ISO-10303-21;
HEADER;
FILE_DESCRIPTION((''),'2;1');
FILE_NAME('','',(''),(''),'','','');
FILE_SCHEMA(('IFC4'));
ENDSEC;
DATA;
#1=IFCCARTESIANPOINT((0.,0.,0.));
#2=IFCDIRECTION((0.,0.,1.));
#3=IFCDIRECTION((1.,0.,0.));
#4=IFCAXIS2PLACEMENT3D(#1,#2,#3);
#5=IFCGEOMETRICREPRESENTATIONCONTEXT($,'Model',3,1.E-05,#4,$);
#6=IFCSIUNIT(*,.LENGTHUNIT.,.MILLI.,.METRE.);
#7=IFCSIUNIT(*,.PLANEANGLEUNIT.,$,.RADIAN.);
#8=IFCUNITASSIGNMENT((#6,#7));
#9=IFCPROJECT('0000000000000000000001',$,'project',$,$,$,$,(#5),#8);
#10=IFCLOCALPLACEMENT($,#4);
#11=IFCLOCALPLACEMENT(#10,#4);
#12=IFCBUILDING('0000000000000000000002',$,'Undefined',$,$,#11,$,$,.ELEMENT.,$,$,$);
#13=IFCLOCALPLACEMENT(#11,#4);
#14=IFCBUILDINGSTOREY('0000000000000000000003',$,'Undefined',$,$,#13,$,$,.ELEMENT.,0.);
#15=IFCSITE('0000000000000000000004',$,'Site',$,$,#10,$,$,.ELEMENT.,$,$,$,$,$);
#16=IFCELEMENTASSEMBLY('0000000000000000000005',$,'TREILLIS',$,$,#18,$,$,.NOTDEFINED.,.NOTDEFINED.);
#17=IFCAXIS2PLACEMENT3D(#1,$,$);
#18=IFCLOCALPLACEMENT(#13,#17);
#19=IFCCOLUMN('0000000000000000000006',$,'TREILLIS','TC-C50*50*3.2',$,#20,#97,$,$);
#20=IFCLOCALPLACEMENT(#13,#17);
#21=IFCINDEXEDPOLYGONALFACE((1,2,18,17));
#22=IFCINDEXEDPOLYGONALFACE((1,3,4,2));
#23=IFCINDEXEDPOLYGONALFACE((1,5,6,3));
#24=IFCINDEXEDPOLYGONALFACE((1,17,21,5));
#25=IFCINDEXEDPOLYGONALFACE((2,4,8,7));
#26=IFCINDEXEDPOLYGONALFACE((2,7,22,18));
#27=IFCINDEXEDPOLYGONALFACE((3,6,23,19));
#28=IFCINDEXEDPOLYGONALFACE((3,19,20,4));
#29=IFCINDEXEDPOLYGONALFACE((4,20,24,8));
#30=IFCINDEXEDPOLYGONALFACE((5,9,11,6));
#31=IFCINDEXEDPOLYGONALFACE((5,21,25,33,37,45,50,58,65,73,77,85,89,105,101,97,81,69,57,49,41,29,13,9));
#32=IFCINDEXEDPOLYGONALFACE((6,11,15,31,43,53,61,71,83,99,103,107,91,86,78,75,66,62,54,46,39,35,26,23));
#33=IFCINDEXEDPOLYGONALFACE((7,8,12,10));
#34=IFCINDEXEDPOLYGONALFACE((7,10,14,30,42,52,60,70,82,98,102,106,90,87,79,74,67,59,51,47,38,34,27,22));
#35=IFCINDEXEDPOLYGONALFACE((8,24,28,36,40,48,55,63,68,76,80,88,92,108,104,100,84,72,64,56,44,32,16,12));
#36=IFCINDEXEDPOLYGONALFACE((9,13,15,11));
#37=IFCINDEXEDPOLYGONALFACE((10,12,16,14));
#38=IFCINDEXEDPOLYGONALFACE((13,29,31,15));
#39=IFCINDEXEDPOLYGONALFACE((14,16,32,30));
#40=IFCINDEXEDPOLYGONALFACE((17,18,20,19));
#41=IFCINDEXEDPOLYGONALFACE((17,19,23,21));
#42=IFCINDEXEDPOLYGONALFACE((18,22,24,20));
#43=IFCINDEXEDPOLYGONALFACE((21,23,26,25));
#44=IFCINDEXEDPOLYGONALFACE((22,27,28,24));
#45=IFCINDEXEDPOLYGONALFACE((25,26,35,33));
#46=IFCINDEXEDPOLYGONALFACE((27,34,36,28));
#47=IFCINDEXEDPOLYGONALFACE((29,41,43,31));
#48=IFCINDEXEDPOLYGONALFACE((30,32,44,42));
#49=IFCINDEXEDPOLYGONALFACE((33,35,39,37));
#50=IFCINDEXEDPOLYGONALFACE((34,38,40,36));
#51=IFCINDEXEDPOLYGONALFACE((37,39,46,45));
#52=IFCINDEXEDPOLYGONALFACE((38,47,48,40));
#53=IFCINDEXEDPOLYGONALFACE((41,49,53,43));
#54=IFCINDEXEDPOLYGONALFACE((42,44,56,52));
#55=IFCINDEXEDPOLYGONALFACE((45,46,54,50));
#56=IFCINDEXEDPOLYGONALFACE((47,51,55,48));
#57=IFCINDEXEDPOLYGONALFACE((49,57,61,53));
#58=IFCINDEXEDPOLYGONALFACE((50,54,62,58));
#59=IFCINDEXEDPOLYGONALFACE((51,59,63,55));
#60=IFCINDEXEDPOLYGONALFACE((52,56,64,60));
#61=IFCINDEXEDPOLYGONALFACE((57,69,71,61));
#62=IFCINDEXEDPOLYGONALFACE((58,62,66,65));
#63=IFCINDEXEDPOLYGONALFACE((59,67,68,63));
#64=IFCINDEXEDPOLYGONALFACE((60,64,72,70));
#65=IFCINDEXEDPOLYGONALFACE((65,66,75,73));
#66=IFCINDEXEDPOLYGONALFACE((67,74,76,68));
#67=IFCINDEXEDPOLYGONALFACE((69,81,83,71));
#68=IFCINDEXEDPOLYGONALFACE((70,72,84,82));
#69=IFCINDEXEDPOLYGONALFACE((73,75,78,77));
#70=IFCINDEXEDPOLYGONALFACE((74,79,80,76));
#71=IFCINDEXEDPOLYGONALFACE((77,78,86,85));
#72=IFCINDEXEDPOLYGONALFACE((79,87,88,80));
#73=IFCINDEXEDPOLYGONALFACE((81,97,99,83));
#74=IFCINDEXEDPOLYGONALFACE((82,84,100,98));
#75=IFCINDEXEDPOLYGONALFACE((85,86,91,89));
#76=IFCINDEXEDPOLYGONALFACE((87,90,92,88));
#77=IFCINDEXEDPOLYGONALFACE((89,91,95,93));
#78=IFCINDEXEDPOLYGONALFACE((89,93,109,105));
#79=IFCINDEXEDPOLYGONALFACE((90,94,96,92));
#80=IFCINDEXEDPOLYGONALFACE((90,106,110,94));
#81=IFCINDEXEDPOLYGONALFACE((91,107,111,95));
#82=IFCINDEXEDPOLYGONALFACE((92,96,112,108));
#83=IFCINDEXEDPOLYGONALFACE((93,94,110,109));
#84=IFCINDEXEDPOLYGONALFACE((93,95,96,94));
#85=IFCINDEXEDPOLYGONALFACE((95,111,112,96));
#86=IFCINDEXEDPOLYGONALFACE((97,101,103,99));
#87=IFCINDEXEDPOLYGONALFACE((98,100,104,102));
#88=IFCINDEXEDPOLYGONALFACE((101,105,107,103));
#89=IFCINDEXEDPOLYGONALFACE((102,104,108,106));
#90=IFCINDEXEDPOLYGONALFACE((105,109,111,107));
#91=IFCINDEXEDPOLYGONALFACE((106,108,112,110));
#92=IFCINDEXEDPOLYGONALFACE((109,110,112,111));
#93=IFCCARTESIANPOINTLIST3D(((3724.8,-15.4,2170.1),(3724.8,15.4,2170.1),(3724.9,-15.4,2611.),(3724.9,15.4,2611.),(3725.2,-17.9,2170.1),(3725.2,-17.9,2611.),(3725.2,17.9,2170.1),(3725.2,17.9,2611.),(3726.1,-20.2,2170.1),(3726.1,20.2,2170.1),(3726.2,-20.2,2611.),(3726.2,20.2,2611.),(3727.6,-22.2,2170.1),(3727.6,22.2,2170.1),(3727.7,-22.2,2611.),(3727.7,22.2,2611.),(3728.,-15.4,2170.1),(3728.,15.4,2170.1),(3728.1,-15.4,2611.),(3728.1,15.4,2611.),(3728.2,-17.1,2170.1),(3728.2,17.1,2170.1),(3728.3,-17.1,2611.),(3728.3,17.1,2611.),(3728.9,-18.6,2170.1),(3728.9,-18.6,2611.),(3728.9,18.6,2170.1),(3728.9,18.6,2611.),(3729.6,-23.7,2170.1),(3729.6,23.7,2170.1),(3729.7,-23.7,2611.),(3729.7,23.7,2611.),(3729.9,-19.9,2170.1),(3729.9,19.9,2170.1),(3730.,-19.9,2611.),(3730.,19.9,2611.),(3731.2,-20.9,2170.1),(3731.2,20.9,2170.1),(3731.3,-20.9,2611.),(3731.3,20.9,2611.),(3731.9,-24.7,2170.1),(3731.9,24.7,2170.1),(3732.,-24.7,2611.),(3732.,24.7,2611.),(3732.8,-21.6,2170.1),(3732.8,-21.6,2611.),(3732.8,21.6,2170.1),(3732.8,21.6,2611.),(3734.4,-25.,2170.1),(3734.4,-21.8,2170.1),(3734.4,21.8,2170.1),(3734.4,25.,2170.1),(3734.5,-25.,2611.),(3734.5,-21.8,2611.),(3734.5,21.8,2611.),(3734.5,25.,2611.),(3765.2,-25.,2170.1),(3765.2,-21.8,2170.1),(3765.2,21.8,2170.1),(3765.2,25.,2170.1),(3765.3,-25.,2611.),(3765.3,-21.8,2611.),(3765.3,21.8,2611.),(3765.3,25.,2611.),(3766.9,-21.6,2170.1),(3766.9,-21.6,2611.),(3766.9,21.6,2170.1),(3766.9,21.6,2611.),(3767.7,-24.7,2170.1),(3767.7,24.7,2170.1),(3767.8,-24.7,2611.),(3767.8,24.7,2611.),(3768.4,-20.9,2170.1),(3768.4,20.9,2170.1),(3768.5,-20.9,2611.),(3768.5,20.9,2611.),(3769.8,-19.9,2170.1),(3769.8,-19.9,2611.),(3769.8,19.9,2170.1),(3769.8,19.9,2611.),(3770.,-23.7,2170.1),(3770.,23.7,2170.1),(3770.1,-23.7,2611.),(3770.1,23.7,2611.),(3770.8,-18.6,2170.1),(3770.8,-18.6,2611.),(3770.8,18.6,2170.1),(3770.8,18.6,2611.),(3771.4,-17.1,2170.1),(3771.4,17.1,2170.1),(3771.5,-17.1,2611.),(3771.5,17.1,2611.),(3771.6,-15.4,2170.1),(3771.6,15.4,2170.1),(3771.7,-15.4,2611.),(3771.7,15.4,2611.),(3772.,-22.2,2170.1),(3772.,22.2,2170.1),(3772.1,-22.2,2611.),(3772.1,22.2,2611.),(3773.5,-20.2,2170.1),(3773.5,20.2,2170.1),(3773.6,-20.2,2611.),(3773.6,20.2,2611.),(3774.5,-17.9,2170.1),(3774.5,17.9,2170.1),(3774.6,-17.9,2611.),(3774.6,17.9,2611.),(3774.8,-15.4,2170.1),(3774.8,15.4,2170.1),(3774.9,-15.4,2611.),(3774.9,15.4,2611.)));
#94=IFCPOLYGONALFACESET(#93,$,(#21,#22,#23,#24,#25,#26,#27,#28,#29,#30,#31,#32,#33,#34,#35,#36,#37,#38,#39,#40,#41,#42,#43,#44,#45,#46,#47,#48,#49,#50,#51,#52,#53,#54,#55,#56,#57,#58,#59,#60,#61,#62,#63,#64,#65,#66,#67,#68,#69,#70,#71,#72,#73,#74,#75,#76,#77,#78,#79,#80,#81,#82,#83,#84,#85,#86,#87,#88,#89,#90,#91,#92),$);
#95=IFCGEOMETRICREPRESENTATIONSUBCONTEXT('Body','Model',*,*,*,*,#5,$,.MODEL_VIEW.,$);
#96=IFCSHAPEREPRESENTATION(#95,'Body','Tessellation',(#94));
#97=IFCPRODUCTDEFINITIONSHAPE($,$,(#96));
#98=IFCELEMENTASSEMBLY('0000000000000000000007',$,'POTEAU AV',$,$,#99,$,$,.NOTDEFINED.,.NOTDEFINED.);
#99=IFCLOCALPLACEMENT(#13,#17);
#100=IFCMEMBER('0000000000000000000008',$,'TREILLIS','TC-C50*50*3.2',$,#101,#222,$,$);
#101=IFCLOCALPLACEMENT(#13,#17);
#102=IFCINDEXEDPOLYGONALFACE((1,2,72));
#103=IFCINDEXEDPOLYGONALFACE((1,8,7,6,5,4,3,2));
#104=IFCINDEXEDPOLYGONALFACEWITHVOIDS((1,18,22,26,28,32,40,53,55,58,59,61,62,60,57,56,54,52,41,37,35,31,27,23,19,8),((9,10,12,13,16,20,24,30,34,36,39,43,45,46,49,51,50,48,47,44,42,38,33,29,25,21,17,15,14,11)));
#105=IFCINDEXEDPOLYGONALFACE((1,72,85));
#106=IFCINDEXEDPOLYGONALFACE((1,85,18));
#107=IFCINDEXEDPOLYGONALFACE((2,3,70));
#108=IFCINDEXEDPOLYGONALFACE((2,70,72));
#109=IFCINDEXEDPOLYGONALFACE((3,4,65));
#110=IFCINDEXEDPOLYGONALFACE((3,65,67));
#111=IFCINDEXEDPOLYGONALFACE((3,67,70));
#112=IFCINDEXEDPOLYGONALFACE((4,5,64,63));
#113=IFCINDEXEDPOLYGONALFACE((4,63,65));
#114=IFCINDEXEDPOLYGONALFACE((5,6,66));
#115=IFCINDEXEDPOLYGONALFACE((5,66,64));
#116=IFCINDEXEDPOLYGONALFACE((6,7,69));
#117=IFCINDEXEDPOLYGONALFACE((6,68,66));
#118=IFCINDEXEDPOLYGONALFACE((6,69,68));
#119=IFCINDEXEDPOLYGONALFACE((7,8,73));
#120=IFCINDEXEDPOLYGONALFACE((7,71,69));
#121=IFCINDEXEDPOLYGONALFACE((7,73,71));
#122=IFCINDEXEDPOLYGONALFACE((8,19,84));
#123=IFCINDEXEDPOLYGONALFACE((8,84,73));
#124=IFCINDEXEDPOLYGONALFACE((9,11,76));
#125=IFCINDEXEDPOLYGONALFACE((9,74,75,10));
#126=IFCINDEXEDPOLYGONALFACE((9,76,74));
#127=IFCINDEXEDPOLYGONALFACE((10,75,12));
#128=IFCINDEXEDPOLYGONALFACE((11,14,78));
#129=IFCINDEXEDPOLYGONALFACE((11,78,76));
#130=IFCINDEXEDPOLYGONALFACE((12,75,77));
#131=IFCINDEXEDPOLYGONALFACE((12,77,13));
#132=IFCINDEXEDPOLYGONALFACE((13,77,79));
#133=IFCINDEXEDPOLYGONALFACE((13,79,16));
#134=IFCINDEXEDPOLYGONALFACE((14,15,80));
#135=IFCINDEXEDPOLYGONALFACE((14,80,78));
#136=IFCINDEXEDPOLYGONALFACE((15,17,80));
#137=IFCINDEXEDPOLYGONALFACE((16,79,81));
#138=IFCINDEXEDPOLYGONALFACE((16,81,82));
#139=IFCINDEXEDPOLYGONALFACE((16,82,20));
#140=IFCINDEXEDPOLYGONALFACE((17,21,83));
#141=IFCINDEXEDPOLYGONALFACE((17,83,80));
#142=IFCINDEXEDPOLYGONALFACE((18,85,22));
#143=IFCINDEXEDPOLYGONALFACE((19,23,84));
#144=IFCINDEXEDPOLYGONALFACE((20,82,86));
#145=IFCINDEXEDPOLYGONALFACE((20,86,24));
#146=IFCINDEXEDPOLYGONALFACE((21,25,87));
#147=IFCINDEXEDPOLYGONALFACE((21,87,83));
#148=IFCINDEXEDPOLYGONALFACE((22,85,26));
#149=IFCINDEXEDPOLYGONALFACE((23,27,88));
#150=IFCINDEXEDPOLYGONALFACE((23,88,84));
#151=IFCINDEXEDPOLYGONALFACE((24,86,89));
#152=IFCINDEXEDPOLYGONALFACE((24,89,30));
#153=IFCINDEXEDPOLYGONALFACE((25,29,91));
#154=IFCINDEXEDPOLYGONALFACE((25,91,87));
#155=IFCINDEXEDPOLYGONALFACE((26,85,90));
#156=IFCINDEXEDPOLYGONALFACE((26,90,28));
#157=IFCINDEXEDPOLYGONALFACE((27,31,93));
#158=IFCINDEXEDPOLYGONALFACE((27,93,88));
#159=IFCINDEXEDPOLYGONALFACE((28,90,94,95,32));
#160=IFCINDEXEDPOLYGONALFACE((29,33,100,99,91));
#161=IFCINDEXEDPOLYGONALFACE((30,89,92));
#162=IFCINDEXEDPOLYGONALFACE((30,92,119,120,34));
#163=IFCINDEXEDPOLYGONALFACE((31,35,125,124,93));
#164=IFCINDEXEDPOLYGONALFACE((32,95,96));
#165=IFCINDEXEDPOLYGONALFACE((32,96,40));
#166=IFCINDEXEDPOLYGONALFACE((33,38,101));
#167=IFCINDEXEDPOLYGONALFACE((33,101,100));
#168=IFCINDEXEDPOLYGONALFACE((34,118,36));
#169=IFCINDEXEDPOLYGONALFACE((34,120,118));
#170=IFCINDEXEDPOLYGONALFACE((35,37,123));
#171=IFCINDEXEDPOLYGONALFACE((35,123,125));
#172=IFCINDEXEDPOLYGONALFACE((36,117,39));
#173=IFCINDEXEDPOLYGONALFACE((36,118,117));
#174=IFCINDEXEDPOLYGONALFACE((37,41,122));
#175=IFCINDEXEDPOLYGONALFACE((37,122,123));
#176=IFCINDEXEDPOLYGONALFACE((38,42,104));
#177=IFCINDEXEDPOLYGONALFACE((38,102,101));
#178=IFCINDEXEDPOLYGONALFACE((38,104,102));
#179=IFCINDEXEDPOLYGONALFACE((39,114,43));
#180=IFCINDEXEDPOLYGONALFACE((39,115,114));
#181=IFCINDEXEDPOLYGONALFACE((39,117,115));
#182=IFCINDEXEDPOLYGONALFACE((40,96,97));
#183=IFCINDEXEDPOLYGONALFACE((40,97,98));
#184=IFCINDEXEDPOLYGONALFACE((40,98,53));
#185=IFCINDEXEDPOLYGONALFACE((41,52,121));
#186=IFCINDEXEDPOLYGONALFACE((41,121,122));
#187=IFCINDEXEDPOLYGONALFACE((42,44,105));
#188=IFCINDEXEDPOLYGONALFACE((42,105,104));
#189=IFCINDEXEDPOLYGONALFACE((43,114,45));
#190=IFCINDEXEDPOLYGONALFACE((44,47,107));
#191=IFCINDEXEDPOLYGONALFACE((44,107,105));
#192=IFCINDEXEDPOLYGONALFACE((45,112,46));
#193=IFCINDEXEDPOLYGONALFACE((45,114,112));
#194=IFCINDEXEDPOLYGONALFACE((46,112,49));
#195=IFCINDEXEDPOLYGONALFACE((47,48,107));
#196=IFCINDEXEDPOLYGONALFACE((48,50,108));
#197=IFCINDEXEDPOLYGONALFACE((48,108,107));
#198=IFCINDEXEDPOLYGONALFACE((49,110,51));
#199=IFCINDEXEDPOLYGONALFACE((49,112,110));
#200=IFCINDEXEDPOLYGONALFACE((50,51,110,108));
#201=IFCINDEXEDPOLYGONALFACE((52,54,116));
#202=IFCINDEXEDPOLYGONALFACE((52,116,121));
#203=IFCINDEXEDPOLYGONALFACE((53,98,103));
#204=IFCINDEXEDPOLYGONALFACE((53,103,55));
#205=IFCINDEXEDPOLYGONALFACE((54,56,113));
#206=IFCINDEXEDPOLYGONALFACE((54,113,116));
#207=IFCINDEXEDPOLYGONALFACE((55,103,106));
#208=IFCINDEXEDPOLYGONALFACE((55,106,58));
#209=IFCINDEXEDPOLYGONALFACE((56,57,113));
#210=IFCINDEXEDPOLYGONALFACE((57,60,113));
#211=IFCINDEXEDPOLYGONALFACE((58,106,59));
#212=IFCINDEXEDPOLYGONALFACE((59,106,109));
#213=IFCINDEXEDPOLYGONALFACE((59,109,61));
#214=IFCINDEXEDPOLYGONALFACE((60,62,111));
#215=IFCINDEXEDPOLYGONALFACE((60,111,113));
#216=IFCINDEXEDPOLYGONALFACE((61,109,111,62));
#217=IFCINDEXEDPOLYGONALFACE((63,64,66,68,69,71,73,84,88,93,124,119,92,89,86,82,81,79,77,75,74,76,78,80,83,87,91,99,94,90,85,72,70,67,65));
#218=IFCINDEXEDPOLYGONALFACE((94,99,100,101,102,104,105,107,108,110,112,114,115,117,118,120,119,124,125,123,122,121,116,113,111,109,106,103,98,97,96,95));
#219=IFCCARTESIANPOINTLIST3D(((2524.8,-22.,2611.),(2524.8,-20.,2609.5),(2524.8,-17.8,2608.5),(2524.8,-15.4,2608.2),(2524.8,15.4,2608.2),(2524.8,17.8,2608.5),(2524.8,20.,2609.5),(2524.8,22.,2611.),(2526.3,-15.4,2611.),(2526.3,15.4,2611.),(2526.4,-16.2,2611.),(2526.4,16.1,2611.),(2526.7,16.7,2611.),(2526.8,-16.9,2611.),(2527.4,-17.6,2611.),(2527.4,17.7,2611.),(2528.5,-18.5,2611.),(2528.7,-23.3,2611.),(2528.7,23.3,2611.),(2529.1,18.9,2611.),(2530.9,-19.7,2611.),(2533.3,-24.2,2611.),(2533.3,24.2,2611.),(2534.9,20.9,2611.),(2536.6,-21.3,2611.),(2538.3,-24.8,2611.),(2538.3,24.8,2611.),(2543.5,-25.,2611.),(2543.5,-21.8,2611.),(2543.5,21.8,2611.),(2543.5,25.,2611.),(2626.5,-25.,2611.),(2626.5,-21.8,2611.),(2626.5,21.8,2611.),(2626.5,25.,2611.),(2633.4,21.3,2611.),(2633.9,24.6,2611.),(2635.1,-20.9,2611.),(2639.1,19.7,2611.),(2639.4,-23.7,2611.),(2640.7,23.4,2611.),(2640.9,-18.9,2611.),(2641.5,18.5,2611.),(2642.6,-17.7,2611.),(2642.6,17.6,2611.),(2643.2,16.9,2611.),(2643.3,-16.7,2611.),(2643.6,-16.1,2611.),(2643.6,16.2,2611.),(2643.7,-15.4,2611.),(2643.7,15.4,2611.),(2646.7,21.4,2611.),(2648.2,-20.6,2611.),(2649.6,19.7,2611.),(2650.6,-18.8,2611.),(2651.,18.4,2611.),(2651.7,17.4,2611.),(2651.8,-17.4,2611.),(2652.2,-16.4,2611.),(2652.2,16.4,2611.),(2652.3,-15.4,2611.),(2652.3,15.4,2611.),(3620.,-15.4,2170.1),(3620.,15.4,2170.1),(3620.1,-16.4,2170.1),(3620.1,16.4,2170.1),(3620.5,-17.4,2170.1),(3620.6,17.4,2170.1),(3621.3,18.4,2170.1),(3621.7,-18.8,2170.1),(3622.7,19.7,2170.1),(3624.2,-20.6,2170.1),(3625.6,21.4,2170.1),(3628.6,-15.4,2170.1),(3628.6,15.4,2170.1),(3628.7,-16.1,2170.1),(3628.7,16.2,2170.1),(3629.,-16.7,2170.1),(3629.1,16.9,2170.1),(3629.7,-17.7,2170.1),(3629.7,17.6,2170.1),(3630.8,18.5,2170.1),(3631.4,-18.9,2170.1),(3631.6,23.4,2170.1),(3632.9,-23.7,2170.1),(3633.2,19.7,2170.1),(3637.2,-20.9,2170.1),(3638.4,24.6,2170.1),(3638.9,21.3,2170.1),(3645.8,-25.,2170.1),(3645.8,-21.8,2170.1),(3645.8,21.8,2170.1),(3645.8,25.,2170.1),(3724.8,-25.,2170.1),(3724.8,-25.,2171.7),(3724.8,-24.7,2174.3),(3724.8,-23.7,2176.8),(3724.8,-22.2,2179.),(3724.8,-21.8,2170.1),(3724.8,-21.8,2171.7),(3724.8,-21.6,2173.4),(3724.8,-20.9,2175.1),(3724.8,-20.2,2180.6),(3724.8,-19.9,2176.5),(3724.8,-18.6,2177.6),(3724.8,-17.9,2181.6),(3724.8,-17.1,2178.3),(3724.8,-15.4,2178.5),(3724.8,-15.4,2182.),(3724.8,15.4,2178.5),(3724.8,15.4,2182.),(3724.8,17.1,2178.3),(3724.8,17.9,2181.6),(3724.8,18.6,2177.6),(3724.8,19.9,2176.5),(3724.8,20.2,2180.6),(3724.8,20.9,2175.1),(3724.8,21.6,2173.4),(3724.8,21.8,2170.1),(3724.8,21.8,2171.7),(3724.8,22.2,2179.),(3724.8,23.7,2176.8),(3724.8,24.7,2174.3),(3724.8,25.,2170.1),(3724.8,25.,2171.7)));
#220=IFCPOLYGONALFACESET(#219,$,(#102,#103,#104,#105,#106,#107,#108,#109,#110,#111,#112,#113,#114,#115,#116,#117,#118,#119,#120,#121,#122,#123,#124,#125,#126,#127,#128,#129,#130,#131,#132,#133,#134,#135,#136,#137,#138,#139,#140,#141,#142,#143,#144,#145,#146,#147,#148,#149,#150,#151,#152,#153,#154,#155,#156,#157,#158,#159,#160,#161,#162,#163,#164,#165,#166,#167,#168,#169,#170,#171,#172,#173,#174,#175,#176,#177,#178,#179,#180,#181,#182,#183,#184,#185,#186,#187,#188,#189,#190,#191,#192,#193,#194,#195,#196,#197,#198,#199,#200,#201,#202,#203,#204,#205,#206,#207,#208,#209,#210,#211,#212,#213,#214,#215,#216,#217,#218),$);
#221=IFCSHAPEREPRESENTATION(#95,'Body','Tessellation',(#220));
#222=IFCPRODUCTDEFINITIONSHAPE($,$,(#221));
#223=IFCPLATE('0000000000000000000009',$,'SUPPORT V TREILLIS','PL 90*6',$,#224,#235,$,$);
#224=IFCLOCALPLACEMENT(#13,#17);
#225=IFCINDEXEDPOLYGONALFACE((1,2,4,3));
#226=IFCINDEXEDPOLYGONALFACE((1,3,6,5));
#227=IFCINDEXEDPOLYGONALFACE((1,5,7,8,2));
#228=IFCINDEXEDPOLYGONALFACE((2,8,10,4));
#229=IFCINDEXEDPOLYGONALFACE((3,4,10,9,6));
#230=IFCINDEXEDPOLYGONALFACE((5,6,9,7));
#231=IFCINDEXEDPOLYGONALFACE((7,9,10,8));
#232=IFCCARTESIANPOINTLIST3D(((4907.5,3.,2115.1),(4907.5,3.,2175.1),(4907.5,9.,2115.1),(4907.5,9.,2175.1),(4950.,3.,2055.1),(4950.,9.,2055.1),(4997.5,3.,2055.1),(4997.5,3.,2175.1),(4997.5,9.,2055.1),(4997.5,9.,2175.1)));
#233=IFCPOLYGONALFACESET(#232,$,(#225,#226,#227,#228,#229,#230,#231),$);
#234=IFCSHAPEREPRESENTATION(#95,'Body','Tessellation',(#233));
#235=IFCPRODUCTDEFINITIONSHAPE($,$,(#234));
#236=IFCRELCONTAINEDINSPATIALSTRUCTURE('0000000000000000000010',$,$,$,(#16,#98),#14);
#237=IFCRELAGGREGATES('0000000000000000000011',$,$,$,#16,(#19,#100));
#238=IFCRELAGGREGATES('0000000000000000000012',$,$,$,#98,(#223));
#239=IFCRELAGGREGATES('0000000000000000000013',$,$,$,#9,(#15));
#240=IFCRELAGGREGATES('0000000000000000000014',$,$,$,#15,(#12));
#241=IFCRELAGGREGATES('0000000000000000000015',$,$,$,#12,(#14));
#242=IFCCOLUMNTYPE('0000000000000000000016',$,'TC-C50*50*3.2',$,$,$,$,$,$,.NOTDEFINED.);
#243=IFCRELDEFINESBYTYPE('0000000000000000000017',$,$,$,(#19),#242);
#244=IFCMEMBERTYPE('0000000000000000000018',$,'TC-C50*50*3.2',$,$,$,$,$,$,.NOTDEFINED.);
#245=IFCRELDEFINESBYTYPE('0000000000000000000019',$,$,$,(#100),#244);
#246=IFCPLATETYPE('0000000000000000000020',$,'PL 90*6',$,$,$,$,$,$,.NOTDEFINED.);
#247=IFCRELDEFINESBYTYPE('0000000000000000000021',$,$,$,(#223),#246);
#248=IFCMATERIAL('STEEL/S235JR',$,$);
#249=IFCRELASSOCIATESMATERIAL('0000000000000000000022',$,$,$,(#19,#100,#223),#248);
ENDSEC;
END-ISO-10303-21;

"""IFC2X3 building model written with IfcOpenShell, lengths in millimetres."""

from ifc_helpers import new_model, si_unit, frame, origin_with_axes, origin_2d_with_axis, place, context, subcontext, project, spatial, polyline, hollow_rectangle, outline, extrude, clip, halfspace, material, type_object, element, aggregate, save


model = new_model("IFC2X3")

# Units and contexts
model_context = context("Model", 3, precision=1e-05, world=origin_with_axes())
body_context = subcontext(model_context, "Body", "Model", "MODEL_VIEW")
ifc_project = project(units=[si_unit("LENGTHUNIT", "METRE", prefix="MILLI"), si_unit("PLANEANGLEUNIT", "RADIAN")], contexts=[model_context])

# Site, building, storey
site_placement = place(None, origin_with_axes())
site = spatial("IfcSite", under=ifc_project, at=site_placement, Name="Site", CompositionType="ELEMENT")
building_placement = place(site_placement, origin_with_axes())
building = spatial("IfcBuilding", under=site, at=building_placement, Name="Undefined", CompositionType="ELEMENT")
storey_placement = place(building_placement, origin_with_axes())
storey = spatial("IfcBuildingStorey", under=building, at=storey_placement, Name="Undefined", CompositionType="ELEMENT", Elevation=0.0)

# Element assemblies, column
ifc_material_1 = material(Name="STEEL/S235JR")
assembly_1_placement = place(storey_placement, origin_with_axes())
assembly_1 = element("IfcElementAssembly", 1, at=assembly_1_placement, inside=storey, Name="TREILLIS", AssemblyPlace="NOTDEFINED", PredefinedType="NOTDEFINED")
column_type_1 = type_object("IfcColumnType", Name="TC-C50*50*3.2", PredefinedType="NOTDEFINED")
column_1_placement = place(assembly_1_placement, frame((3749.8, 0.0, 2145.1), z_axis=(0.000134, 0.0, 1.0), x_axis=(-1.0, 0.0, 0.000134)))
column_1 = element("IfcColumn", 2, at=column_1_placement, type_object=column_type_1, material=ifc_material_1, Name="TREILLIS", Description="TC-C50*50*3.2", context=body_context, shape_type="Clipping", body=[
    clip(clip(extrude(hollow_rectangle(XDim=50.0, YDim=50.0, WallThickness=3.2, InnerFilletRadius=6.4, OuterFilletRadius=9.6, at=origin_2d_with_axis()), frame((0.0, 0.0, 500.1), z_axis=(0.0, 0.0, -1.0), x_axis=(0.0, 1.0, 0.0)), (0.0, 0.0, 1.0), 500.1), halfspace(frame((-25.2, 25.0, 465.9), z_axis=(0.000134, 0.0, 1.0), x_axis=(1.0, 0.0, -0.000134)), False)), halfspace(frame((-25.2, -25.0, 25.0), z_axis=(-0.000134, 0.0, -1.0), x_axis=(1.0, 0.0, -0.000134)), False)),
])
assembly_2_placement = place(storey_placement, origin_with_axes())
assembly_2 = element("IfcElementAssembly", 3, at=assembly_2_placement, inside=storey, Name="POTEAU AV", AssemblyPlace="NOTDEFINED", PredefinedType="NOTDEFINED")

# Member
member_type = type_object("IfcMemberType", Name="TC-C50*50*3.2", PredefinedType="NOTDEFINED")
member_1_placement = place(assembly_1_placement, frame((3749.8, 0.0, 2145.1), z_axis=(0.371395, 0.0, 0.928475), x_axis=(-0.928475, 0.0, 0.371395)))
member_1 = element("IfcMember", 4, at=member_1_placement, type_object=member_type, material=ifc_material_1, Name="TREILLIS", Description="TC-C50*50*3.2", context=body_context, shape_type="Clipping", body=[
    clip(clip(clip(clip(extrude(hollow_rectangle(XDim=50.0, YDim=50.0, WallThickness=3.2, InnerFilletRadius=6.4, OuterFilletRadius=9.6, at=origin_2d_with_axis()), frame((1346.3, 0.0, 0.0), z_axis=(-1.0, 0.0, 0.0), x_axis=(0.0, -1.0, 0.0)), (0.0, 0.0, 1.0), 1346.3), halfspace(frame((1309.4, -25.0, -25.0), z_axis=(0.928475, -0.000001, -0.371395), x_axis=(0.371395, 0.0, 0.928475)), False)), halfspace(frame((16.9, 25.0, -25.0), z_axis=(-0.928525, 0.000001, 0.371271), x_axis=(0.371271, 0.0, 0.928525)), False)), halfspace(frame((129.8, 25.0, -25.0), z_axis=(-0.371395, 0.0, -0.928475), x_axis=(-0.928475, 0.0, 0.371395)), False)), halfspace(frame((1317.0, -25.0, -25.0), z_axis=(0.371395, 0.0, 0.928475), x_axis=(-0.928475, 0.0, 0.371395)), False)),
])

# Plate
plate_type_1 = type_object("IfcPlateType", Name="PL 90*6", PredefinedType="NOTDEFINED")
plate_1_placement = place(assembly_2_placement, frame((4952.5, 6.0, 2175.1), z_axis=(0.0, 1.0, 0.0), x_axis=(0.0, 0.0, -1.0)))
plate_1 = element("IfcPlate", 5, at=plate_1_placement, type_object=plate_type_1, material=ifc_material_1, Name="SUPPORT V TREILLIS", Description="PL 90*6", context=body_context, shape_type="Clipping", body=[
    clip(extrude(outline(polyline([(120.0, 2.5), (120.0, -45.0), (0.0, -45.0), (0.0, 45.0), (60.0, 45.0), (120.0, 2.5)])), frame((0.0, 0.0, -3.0), z_axis=(0.0, 0.0, 1.0), x_axis=(1.0, 0.0, 0.0)), (0.0, 0.0, 1.0), 6.0), halfspace(frame((187.1, -45.0, 3.0), z_axis=(0.578017, 0.816024, 0.0), x_axis=(-0.816024, 0.578017, 0.0)), False)),
])
aggregate(assembly_1, [column_1, member_1])

aggregate(assembly_2, [plate_1])

save(model, "model.ifc")
